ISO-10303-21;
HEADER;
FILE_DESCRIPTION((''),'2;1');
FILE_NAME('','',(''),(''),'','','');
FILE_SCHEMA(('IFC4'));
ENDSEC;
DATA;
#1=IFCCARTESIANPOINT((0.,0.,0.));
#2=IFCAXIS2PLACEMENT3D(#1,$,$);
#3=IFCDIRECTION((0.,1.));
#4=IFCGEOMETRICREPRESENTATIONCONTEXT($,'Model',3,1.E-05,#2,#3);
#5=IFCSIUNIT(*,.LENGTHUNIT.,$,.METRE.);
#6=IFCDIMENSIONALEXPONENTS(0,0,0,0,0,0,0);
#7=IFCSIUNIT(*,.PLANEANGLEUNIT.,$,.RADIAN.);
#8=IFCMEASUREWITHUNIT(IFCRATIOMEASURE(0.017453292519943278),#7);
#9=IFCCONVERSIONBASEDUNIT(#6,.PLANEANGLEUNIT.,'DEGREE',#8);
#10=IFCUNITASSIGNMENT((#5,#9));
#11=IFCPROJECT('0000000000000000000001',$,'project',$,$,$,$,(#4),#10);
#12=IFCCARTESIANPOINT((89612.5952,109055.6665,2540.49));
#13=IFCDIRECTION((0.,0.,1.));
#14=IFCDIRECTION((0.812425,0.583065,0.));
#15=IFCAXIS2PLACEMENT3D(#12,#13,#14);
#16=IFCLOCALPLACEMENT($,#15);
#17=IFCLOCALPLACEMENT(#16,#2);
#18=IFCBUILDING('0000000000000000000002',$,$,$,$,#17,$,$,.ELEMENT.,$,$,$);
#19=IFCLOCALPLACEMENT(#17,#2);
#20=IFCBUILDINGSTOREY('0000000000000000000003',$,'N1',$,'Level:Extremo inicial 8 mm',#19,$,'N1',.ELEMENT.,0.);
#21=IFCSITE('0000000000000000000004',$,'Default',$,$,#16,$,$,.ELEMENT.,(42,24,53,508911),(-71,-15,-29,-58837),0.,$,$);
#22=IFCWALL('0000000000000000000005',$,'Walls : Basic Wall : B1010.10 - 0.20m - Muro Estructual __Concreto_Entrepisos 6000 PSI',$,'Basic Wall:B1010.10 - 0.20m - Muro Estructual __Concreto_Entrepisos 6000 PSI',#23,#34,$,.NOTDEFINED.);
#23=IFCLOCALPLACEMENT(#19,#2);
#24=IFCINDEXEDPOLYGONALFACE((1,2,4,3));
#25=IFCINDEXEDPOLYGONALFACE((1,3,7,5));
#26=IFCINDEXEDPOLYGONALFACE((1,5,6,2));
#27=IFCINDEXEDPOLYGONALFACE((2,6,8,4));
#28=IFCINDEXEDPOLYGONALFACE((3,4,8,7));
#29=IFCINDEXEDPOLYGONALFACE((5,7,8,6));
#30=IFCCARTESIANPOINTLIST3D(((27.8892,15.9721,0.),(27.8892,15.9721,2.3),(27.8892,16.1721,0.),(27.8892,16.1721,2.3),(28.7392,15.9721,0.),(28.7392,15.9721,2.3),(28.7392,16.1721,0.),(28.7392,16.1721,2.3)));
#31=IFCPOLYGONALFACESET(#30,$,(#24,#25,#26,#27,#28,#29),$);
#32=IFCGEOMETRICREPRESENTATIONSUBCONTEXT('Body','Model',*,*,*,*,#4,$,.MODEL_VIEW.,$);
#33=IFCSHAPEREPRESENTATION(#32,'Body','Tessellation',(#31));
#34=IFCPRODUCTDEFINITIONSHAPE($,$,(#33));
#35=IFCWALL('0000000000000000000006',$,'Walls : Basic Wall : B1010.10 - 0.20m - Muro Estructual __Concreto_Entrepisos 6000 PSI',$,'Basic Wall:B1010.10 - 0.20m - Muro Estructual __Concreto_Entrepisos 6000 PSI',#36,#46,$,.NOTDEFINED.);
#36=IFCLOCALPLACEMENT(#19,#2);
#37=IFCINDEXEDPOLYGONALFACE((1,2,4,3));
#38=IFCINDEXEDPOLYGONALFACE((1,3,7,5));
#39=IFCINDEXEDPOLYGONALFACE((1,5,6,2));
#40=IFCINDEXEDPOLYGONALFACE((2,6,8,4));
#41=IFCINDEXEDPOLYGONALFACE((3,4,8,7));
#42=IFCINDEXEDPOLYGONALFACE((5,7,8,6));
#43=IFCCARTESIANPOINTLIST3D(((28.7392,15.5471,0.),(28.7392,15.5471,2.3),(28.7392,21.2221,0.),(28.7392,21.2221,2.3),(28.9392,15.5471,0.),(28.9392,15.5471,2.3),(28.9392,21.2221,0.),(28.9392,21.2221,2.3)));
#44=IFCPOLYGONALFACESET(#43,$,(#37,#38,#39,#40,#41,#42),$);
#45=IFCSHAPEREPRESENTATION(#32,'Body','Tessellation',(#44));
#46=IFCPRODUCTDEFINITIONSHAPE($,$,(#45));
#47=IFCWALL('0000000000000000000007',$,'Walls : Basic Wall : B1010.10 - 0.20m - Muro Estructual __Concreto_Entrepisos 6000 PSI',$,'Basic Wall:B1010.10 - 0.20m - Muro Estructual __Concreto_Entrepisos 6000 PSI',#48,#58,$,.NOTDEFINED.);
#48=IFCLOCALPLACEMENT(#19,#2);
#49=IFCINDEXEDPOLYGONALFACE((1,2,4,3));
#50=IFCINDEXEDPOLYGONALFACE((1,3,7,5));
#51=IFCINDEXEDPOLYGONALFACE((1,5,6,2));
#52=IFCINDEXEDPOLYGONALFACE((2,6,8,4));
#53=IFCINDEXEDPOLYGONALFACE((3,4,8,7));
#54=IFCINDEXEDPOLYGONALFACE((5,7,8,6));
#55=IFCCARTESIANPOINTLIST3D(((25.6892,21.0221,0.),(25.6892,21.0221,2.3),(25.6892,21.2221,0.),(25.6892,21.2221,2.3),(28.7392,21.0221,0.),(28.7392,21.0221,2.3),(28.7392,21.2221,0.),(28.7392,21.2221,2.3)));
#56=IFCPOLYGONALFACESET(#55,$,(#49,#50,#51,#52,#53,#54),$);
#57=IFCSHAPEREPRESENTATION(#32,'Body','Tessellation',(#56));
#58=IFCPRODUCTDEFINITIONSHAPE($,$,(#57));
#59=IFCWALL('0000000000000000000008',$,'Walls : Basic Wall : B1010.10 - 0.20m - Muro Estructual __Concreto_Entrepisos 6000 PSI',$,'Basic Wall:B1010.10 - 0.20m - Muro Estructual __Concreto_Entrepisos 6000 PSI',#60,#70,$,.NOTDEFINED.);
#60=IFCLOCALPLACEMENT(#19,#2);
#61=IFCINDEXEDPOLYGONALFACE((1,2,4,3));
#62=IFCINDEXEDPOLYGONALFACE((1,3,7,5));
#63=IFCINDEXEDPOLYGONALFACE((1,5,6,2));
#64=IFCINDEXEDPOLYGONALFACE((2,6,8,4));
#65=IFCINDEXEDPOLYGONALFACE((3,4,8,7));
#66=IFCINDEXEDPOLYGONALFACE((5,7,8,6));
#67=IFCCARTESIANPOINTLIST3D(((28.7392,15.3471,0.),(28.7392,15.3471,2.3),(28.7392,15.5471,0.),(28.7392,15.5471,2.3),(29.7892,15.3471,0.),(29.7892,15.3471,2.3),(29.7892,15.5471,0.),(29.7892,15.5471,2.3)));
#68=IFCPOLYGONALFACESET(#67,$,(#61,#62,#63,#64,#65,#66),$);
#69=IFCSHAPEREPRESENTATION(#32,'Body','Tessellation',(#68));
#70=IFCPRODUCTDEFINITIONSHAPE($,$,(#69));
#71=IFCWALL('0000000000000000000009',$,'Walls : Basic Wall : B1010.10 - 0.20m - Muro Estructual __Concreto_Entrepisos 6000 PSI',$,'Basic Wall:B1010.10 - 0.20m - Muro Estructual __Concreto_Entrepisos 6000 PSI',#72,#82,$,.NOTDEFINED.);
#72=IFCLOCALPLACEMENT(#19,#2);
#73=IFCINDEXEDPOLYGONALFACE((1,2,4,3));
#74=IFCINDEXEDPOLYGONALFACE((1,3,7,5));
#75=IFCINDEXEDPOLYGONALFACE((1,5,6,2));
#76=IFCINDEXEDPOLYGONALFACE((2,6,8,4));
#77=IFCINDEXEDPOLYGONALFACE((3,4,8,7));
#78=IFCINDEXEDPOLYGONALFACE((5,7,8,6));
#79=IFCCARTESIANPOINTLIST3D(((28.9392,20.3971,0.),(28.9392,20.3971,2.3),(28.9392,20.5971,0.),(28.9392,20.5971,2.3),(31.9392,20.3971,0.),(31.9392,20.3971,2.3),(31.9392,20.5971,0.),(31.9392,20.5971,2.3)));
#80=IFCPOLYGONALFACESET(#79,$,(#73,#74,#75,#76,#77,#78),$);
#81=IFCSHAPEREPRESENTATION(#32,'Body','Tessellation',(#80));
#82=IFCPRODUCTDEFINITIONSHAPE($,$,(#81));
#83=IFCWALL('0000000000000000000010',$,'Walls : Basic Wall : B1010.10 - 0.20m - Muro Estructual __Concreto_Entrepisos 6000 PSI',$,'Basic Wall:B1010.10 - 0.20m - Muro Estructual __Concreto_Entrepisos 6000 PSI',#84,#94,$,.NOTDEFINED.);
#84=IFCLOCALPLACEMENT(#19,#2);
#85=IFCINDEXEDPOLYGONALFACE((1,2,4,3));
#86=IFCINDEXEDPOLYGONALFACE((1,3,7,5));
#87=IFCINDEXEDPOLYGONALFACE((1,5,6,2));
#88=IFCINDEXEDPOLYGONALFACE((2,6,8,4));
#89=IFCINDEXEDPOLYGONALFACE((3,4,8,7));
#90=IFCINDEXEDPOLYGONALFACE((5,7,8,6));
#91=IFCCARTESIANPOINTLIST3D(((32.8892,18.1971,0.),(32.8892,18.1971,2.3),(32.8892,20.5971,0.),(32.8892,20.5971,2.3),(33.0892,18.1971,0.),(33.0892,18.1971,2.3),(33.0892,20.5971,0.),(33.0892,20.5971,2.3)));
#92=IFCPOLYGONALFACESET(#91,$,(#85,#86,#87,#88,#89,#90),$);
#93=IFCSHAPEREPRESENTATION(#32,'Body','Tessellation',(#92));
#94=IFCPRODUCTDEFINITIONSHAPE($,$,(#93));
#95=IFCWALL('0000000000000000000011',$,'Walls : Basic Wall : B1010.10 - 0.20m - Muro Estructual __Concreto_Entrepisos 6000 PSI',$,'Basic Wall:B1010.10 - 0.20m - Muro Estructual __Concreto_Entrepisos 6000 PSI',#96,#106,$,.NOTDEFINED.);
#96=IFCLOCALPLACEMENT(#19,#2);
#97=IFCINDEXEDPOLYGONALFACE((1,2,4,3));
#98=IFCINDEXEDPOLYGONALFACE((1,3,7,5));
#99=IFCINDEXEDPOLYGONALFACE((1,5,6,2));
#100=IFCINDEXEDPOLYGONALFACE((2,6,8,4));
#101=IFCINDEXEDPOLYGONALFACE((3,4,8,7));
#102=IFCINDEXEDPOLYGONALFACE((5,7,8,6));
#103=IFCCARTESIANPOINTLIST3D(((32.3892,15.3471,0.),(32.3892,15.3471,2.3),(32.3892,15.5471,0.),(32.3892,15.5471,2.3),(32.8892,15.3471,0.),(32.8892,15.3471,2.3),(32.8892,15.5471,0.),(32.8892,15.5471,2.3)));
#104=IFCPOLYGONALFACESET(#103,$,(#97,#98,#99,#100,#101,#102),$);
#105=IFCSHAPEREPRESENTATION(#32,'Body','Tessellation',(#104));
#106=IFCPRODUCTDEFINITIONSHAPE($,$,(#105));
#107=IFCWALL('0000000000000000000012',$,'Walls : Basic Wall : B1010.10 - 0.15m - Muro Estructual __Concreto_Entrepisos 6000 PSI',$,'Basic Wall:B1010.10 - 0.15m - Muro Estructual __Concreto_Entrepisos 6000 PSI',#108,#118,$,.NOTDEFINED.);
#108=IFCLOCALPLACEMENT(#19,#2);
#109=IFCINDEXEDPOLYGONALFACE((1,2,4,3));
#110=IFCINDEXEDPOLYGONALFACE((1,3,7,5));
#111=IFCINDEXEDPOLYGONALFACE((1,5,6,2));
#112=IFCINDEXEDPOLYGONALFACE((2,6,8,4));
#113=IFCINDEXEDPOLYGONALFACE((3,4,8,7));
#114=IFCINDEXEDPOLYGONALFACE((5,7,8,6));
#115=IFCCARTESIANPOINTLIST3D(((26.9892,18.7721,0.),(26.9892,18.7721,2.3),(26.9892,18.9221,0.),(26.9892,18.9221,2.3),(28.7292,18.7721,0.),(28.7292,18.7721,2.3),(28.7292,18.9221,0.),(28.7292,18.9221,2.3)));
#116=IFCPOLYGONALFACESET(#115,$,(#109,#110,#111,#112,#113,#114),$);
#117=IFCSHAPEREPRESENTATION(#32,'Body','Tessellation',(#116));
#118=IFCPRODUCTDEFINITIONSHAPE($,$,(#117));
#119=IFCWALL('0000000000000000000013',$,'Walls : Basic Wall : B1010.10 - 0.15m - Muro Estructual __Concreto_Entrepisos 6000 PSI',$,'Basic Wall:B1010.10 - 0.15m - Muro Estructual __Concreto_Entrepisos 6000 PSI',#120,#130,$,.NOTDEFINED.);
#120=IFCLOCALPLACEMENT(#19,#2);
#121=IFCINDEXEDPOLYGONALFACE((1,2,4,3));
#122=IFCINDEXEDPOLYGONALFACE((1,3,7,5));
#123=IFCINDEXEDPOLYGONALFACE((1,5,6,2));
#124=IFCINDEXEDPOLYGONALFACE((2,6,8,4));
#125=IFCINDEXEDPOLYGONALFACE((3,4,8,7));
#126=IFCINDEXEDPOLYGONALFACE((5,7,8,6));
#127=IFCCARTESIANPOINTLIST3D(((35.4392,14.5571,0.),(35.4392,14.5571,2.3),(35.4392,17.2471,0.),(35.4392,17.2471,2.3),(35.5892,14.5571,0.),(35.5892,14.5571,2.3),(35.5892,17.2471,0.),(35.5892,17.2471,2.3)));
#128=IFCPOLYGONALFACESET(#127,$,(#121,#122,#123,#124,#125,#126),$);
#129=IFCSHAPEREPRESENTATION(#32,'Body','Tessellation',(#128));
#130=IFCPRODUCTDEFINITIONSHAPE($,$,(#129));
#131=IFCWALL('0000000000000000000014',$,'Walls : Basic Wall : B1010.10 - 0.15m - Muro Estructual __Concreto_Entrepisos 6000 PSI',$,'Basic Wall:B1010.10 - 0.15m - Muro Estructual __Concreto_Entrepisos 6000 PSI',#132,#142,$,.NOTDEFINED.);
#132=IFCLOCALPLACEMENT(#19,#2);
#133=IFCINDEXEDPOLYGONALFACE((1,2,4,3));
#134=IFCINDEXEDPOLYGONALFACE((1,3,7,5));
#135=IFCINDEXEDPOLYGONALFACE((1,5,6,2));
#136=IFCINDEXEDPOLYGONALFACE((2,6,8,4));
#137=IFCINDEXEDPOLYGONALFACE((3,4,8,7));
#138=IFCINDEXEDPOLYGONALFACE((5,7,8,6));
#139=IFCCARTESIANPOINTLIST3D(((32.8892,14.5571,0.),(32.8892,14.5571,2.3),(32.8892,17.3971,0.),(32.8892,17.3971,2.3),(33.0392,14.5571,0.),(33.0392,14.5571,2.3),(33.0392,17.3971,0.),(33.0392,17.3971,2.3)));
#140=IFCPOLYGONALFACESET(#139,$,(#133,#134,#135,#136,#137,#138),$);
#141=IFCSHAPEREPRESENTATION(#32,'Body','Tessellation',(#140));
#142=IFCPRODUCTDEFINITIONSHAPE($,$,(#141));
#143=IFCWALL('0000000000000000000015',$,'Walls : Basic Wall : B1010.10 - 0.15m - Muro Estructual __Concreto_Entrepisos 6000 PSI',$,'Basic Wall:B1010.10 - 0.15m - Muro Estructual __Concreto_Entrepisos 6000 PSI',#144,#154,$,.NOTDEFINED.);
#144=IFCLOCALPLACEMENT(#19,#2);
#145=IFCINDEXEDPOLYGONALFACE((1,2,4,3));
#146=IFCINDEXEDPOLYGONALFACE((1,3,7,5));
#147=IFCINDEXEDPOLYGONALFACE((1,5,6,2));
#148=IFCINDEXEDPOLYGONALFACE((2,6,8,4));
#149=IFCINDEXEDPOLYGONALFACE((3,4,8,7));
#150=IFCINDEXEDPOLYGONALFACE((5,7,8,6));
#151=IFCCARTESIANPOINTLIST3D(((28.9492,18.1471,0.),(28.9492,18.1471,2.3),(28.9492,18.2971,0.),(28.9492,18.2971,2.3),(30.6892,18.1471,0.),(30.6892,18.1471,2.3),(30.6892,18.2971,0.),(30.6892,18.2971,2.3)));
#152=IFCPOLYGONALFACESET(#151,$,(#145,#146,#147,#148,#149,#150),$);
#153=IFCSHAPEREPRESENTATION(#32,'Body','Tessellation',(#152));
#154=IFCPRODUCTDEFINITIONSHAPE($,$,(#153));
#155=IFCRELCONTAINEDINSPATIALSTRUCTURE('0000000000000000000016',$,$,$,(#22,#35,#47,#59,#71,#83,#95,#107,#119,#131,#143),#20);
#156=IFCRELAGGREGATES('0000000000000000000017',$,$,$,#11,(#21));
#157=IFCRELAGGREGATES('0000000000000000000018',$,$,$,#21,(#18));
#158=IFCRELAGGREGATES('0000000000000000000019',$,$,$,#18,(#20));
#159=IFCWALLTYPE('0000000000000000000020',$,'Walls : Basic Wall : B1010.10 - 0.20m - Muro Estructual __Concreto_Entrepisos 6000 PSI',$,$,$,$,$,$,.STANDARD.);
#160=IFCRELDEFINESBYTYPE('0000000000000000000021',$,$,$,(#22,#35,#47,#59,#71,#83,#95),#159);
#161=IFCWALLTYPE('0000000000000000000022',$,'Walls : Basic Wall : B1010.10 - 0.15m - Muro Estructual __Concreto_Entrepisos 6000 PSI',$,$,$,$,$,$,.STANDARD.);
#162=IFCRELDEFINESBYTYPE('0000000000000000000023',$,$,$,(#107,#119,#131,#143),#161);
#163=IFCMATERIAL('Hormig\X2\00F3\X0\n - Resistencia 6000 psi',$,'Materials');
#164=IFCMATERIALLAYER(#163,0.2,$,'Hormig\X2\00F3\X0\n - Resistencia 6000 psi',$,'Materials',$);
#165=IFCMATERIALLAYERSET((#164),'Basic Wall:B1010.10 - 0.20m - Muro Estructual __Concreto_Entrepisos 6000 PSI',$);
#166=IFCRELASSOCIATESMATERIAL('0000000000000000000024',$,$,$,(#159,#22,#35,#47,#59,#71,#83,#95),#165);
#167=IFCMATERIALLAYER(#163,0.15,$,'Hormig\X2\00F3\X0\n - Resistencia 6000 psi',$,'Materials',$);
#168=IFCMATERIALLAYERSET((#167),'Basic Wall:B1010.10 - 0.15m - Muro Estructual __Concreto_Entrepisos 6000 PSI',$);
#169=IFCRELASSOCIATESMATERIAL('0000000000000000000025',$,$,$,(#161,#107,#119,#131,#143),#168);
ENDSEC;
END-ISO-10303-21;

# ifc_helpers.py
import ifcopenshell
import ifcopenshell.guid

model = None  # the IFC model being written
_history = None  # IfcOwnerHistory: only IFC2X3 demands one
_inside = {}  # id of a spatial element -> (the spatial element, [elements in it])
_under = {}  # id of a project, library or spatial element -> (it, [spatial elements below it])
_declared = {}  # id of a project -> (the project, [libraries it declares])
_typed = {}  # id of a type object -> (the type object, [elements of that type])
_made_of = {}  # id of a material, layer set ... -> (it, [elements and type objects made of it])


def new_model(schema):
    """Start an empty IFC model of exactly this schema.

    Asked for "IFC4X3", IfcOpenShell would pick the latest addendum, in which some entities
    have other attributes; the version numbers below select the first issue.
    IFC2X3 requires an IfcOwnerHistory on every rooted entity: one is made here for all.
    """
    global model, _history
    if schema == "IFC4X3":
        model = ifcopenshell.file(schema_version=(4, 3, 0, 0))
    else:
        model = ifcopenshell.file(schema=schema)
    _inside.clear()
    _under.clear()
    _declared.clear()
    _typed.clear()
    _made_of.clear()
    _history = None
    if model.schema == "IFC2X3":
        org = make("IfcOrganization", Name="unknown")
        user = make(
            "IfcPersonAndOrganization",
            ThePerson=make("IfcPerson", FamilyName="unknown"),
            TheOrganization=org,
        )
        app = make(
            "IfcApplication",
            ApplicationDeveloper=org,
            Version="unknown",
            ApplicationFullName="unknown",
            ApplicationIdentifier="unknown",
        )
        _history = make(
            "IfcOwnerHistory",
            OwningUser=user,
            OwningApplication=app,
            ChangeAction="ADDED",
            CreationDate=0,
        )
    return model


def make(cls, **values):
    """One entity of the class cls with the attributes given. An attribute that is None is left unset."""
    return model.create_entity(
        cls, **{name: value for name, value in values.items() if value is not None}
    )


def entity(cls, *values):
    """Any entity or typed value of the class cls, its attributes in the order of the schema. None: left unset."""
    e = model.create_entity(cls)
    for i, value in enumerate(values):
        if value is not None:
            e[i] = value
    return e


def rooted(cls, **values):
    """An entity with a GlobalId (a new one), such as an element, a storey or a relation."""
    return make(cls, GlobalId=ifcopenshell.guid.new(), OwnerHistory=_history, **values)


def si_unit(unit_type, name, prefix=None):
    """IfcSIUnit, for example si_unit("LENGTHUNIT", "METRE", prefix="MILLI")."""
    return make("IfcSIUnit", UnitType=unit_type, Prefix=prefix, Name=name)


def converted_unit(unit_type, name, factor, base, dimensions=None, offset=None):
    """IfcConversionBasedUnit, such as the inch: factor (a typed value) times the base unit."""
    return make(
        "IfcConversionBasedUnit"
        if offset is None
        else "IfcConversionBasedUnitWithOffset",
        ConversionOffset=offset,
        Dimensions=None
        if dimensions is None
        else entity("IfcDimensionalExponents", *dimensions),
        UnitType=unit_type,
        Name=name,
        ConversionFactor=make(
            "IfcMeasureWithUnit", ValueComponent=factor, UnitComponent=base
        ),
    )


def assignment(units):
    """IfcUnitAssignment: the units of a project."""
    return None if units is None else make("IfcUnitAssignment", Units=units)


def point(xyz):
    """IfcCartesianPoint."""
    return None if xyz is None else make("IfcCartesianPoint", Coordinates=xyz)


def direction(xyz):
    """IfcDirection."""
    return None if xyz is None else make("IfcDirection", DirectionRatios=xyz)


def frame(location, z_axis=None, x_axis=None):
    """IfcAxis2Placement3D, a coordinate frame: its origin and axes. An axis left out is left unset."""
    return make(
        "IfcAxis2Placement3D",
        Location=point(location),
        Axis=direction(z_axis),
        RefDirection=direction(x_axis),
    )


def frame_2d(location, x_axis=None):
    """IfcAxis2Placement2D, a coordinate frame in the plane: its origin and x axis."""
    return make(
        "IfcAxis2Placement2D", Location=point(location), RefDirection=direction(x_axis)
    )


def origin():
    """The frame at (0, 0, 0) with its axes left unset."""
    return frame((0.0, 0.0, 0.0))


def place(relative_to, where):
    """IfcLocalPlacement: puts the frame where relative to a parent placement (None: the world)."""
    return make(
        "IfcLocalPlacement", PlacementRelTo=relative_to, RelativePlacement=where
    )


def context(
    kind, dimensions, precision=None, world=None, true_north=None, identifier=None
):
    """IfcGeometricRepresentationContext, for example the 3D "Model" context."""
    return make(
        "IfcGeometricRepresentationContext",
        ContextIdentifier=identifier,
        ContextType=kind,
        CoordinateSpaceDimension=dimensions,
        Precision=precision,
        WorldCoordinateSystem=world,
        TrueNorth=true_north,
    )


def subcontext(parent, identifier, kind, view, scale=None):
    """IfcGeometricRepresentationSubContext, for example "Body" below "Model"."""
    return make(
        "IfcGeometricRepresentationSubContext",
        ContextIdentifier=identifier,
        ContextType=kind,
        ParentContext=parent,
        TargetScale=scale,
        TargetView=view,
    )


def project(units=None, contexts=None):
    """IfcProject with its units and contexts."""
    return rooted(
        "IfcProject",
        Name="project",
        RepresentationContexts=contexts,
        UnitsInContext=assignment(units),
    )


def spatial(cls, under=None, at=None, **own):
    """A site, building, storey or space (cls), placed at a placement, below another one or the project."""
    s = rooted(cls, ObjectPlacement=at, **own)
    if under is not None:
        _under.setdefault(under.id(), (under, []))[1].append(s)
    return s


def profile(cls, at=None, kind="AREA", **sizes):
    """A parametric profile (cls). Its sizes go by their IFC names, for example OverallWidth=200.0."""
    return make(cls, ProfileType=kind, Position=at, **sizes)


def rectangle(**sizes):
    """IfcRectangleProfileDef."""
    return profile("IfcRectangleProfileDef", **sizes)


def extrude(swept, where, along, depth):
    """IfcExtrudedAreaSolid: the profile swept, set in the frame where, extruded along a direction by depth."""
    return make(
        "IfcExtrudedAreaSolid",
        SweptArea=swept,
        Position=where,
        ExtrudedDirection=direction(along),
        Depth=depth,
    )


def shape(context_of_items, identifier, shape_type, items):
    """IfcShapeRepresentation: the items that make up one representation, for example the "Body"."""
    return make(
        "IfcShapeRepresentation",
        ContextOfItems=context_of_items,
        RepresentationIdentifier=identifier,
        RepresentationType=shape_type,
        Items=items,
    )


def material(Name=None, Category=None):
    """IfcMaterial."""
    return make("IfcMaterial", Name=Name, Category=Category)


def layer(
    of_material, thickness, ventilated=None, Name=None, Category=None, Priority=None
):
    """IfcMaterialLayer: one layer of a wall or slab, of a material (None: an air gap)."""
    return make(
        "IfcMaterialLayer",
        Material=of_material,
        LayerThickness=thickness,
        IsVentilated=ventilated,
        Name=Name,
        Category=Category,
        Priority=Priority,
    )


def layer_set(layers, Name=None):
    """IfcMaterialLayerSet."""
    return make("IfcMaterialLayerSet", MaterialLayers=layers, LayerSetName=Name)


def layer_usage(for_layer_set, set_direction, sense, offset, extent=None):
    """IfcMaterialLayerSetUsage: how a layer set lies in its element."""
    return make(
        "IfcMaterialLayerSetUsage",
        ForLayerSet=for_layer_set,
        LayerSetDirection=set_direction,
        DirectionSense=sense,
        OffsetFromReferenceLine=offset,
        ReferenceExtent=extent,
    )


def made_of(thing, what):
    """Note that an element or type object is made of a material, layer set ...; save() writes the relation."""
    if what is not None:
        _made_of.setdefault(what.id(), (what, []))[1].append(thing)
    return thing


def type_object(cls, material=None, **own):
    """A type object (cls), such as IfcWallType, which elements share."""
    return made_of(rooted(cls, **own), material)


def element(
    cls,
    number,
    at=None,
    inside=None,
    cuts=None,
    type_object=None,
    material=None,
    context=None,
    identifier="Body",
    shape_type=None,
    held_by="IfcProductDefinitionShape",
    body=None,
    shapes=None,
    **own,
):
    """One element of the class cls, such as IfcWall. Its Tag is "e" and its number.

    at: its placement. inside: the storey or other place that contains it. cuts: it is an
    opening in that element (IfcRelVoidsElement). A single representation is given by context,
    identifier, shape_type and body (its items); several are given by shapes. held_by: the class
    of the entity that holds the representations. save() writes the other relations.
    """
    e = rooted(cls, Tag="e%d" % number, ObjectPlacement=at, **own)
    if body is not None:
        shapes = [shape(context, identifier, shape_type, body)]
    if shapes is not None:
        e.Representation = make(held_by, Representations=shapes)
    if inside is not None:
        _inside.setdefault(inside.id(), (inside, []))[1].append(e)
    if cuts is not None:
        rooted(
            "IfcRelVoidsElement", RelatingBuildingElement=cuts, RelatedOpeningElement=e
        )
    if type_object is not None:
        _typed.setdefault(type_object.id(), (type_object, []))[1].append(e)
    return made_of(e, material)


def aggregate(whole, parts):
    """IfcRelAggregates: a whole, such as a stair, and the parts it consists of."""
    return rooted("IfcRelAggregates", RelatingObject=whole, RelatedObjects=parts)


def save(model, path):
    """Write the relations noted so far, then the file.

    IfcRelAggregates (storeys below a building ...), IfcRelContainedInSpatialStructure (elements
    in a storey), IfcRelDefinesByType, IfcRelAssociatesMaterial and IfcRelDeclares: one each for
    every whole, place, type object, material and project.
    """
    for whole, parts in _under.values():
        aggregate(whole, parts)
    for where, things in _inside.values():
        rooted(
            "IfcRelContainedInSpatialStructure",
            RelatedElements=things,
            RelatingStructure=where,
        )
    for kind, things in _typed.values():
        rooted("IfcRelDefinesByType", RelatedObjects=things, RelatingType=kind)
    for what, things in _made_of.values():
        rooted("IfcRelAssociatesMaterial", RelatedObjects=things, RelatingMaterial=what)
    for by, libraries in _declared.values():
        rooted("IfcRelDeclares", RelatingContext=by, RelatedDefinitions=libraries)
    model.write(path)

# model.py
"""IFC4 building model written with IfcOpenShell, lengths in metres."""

from ifc_helpers import new_model, entity, si_unit, converted_unit, direction, frame, frame_2d, origin, place, context, subcontext, project, spatial, rectangle, extrude, material, layer, layer_set, layer_usage, type_object, element, save


model = new_model("IFC4")

# Units and contexts
model_context = context("Model", 3, precision=1e-05, world=origin(), true_north=direction((0.0, 1.0)))
body_context = subcontext(model_context, "Body", "Model", "MODEL_VIEW")
ifc_project = project(units=[si_unit("LENGTHUNIT", "METRE"), converted_unit("PLANEANGLEUNIT", "DEGREE", entity("IfcRatioMeasure", 0.017453292519943278), si_unit("PLANEANGLEUNIT", "RADIAN"), dimensions=[0, 0, 0, 0, 0, 0, 0])], contexts=[model_context])

# Site, building, storey
site_placement = place(None, frame((89612.5952, 109055.6665, 2540.49), z_axis=(0.0, 0.0, 1.0), x_axis=(0.812425, 0.583065, 0.0)))
site = spatial("IfcSite", under=ifc_project, at=site_placement, Name="Default", CompositionType="ELEMENT", RefLatitude=(42, 24, 53, 508911), RefLongitude=(-71, -15, -29, -58837), RefElevation=0.0)
building_placement = place(site_placement, origin())
building = spatial("IfcBuilding", under=site, at=building_placement, CompositionType="ELEMENT")
storey_placement = place(building_placement, origin())
storey = spatial("IfcBuildingStorey", under=building, at=storey_placement, Name="N1", ObjectType="Level:Extremo inicial 8 mm", LongName="N1", CompositionType="ELEMENT", Elevation=0.0)

# Walls
ifc_material_1 = material(Name="Hormigón - Resistencia 6000 psi", Category="Materials")
ifc_layer_1 = layer(ifc_material_1, 0.2, Name="Hormigón - Resistencia 6000 psi", Category="Materials")
ifc_layer_set_1 = layer_set([ifc_layer_1], Name="Basic Wall:B1010.10 - 0.20m - Muro Estructual __Concreto_Entrepisos 6000 PSI")
ifc_layer_usage_1 = layer_usage(ifc_layer_set_1, "AXIS2", "POSITIVE", -0.1)
wall_type_1 = type_object("IfcWallType", Name="Walls : Basic Wall : B1010.10 - 0.20m - Muro Estructual __Concreto_Entrepisos 6000 PSI", PredefinedType="STANDARD", material=ifc_layer_set_1)
wall_1_placement = place(storey_placement, frame((27.8892, 16.0721, 0.0)))
element("IfcWall", 1, at=wall_1_placement, inside=storey, type_object=wall_type_1, material=ifc_layer_usage_1, Name="Walls : Basic Wall : B1010.10 - 0.20m - Muro Estructual __Concreto_Entrepisos 6000 PSI", ObjectType="Basic Wall:B1010.10 - 0.20m - Muro Estructual __Concreto_Entrepisos 6000 PSI", PredefinedType="NOTDEFINED", context=body_context, shape_type="SweptSolid", body=[
    extrude(rectangle(XDim=0.85, YDim=0.2, at=frame_2d((0.425, 0.0), x_axis=(-1.0, 0.0))), origin(), (0.0, 0.0, 1.0), 2.3),
])
ifc_layer_usage_2 = layer_usage(ifc_layer_set_1, "AXIS2", "POSITIVE", -0.1)
wall_2_placement = place(storey_placement, frame((28.8392, 15.5471, 0.0), z_axis=(0.0, 0.0, 1.0), x_axis=(0.0, 1.0, 0.0)))
element("IfcWall", 2, at=wall_2_placement, inside=storey, type_object=wall_type_1, material=ifc_layer_usage_2, Name="Walls : Basic Wall : B1010.10 - 0.20m - Muro Estructual __Concreto_Entrepisos 6000 PSI", ObjectType="Basic Wall:B1010.10 - 0.20m - Muro Estructual __Concreto_Entrepisos 6000 PSI", PredefinedType="NOTDEFINED", context=body_context, shape_type="SweptSolid", body=[
    extrude(rectangle(XDim=5.675, YDim=0.2, at=frame_2d((2.8375, 0.0), x_axis=(-1.0, 0.0))), origin(), (0.0, 0.0, 1.0), 2.3),
])
ifc_layer_usage_3 = layer_usage(ifc_layer_set_1, "AXIS2", "POSITIVE", -0.1)
wall_3_placement = place(storey_placement, frame((28.7392, 21.1221, 0.0), z_axis=(0.0, 0.0, 1.0), x_axis=(-1.0, 0.0, 0.0)))
element("IfcWall", 3, at=wall_3_placement, inside=storey, type_object=wall_type_1, material=ifc_layer_usage_3, Name="Walls : Basic Wall : B1010.10 - 0.20m - Muro Estructual __Concreto_Entrepisos 6000 PSI", ObjectType="Basic Wall:B1010.10 - 0.20m - Muro Estructual __Concreto_Entrepisos 6000 PSI", PredefinedType="NOTDEFINED", context=body_context, shape_type="SweptSolid", body=[
    extrude(rectangle(XDim=3.05, YDim=0.2, at=frame_2d((1.525, 0.0), x_axis=(-1.0, 0.0))), origin(), (0.0, 0.0, 1.0), 2.3),
])
ifc_layer_usage_4 = layer_usage(ifc_layer_set_1, "AXIS2", "NEGATIVE", 0.1)
wall_4_placement = place(storey_placement, frame((29.7892, 15.4471, 0.0), z_axis=(0.0, 0.0, 1.0), x_axis=(-1.0, 0.0, 0.0)))
element("IfcWall", 4, at=wall_4_placement, inside=storey, type_object=wall_type_1, material=ifc_layer_usage_4, Name="Walls : Basic Wall : B1010.10 - 0.20m - Muro Estructual __Concreto_Entrepisos 6000 PSI", ObjectType="Basic Wall:B1010.10 - 0.20m - Muro Estructual __Concreto_Entrepisos 6000 PSI", PredefinedType="NOTDEFINED", context=body_context, shape_type="SweptSolid", body=[
    extrude(rectangle(XDim=1.05, YDim=0.2, at=frame_2d((0.525, 0.0), x_axis=(-1.0, 0.0))), origin(), (0.0, 0.0, 1.0), 2.3),
])
ifc_layer_usage_5 = layer_usage(ifc_layer_set_1, "AXIS2", "NEGATIVE", 0.1)
wall_5_placement = place(storey_placement, frame((28.9392, 20.4971, 0.0)))
element("IfcWall", 5, at=wall_5_placement, inside=storey, type_object=wall_type_1, material=ifc_layer_usage_5, Name="Walls : Basic Wall : B1010.10 - 0.20m - Muro Estructual __Concreto_Entrepisos 6000 PSI", ObjectType="Basic Wall:B1010.10 - 0.20m - Muro Estructual __Concreto_Entrepisos 6000 PSI", PredefinedType="NOTDEFINED", context=body_context, shape_type="SweptSolid", body=[
    extrude(rectangle(XDim=3.0, YDim=0.2, at=frame_2d((1.5, 0.0), x_axis=(-1.0, 0.0))), origin(), (0.0, 0.0, 1.0), 2.3),
])
ifc_layer_usage_6 = layer_usage(ifc_layer_set_1, "AXIS2", "NEGATIVE", 0.1)
wall_6_placement = place(storey_placement, frame((32.9892, 18.1971, 0.0), z_axis=(0.0, 0.0, 1.0), x_axis=(0.0, 1.0, 0.0)))
element("IfcWall", 6, at=wall_6_placement, inside=storey, type_object=wall_type_1, material=ifc_layer_usage_6, Name="Walls : Basic Wall : B1010.10 - 0.20m - Muro Estructual __Concreto_Entrepisos 6000 PSI", ObjectType="Basic Wall:B1010.10 - 0.20m - Muro Estructual __Concreto_Entrepisos 6000 PSI", PredefinedType="NOTDEFINED", context=body_context, shape_type="SweptSolid", body=[
    extrude(rectangle(XDim=2.4, YDim=0.2, at=frame_2d((1.2, 0.0), x_axis=(-1.0, 0.0))), origin(), (0.0, 0.0, 1.0), 2.3),
])
ifc_layer_usage_7 = layer_usage(ifc_layer_set_1, "AXIS2", "NEGATIVE", 0.1)
wall_7_placement = place(storey_placement, frame((32.3892, 15.4471, 0.0)))
element("IfcWall", 7, at=wall_7_placement, inside=storey, type_object=wall_type_1, material=ifc_layer_usage_7, Name="Walls : Basic Wall : B1010.10 - 0.20m - Muro Estructual __Concreto_Entrepisos 6000 PSI", ObjectType="Basic Wall:B1010.10 - 0.20m - Muro Estructual __Concreto_Entrepisos 6000 PSI", PredefinedType="NOTDEFINED", context=body_context, shape_type="SweptSolid", body=[
    extrude(rectangle(XDim=0.5, YDim=0.2, at=frame_2d((0.25, 0.0), x_axis=(-1.0, 0.0))), origin(), (0.0, 0.0, 1.0), 2.3),
])
ifc_layer_2 = layer(ifc_material_1, 0.15, Name="Hormigón - Resistencia 6000 psi", Category="Materials")
ifc_layer_set_2 = layer_set([ifc_layer_2], Name="Basic Wall:B1010.10 - 0.15m - Muro Estructual __Concreto_Entrepisos 6000 PSI")
ifc_layer_usage_8 = layer_usage(ifc_layer_set_2, "AXIS2", "POSITIVE", -0.075)
wall_type_2 = type_object("IfcWallType", Name="Walls : Basic Wall : B1010.10 - 0.15m - Muro Estructual __Concreto_Entrepisos 6000 PSI", PredefinedType="STANDARD", material=ifc_layer_set_2)
wall_8_placement = place(storey_placement, frame((26.9892, 18.8471, 0.0)))
element("IfcWall", 8, at=wall_8_placement, inside=storey, type_object=wall_type_2, material=ifc_layer_usage_8, Name="Walls : Basic Wall : B1010.10 - 0.15m - Muro Estructual __Concreto_Entrepisos 6000 PSI", ObjectType="Basic Wall:B1010.10 - 0.15m - Muro Estructual __Concreto_Entrepisos 6000 PSI", PredefinedType="NOTDEFINED", context=body_context, shape_type="SweptSolid", body=[
    extrude(rectangle(XDim=1.74, YDim=0.15, at=frame_2d((0.87, 0.0), x_axis=(-1.0, 0.0))), origin(), (0.0, 0.0, 1.0), 2.3),
])
ifc_layer_usage_9 = layer_usage(ifc_layer_set_2, "AXIS2", "NEGATIVE", 0.075)
wall_9_placement = place(storey_placement, frame((35.5142, 14.5571, 0.0), z_axis=(0.0, 0.0, 1.0), x_axis=(0.0, 1.0, 0.0)))
element("IfcWall", 9, at=wall_9_placement, inside=storey, type_object=wall_type_2, material=ifc_layer_usage_9, Name="Walls : Basic Wall : B1010.10 - 0.15m - Muro Estructual __Concreto_Entrepisos 6000 PSI", ObjectType="Basic Wall:B1010.10 - 0.15m - Muro Estructual __Concreto_Entrepisos 6000 PSI", PredefinedType="NOTDEFINED", context=body_context, shape_type="SweptSolid", body=[
    extrude(rectangle(XDim=2.69, YDim=0.15, at=frame_2d((1.345, 0.0), x_axis=(-1.0, 0.0))), origin(), (0.0, 0.0, 1.0), 2.3),
])
ifc_layer_usage_10 = layer_usage(ifc_layer_set_2, "AXIS2", "NEGATIVE", 0.075)
wall_10_placement = place(storey_placement, frame((32.9642, 14.5571, 0.0), z_axis=(0.0, 0.0, 1.0), x_axis=(0.0, 1.0, 0.0)))
element("IfcWall", 10, at=wall_10_placement, inside=storey, type_object=wall_type_2, material=ifc_layer_usage_10, Name="Walls : Basic Wall : B1010.10 - 0.15m - Muro Estructual __Concreto_Entrepisos 6000 PSI", ObjectType="Basic Wall:B1010.10 - 0.15m - Muro Estructual __Concreto_Entrepisos 6000 PSI", PredefinedType="NOTDEFINED", context=body_context, shape_type="SweptSolid", body=[
    extrude(rectangle(XDim=2.84, YDim=0.15, at=frame_2d((1.42, 0.0), x_axis=(-1.0, 0.0))), origin(), (0.0, 0.0, 1.0), 2.3),
])
ifc_layer_usage_11 = layer_usage(ifc_layer_set_2, "AXIS2", "NEGATIVE", 0.075)
wall_11_placement = place(storey_placement, frame((30.6892, 18.2221, 0.0), z_axis=(0.0, 0.0, 1.0), x_axis=(-1.0, 0.0, 0.0)))
element("IfcWall", 11, at=wall_11_placement, inside=storey, type_object=wall_type_2, material=ifc_layer_usage_11, Name="Walls : Basic Wall : B1010.10 - 0.15m - Muro Estructual __Concreto_Entrepisos 6000 PSI", ObjectType="Basic Wall:B1010.10 - 0.15m - Muro Estructual __Concreto_Entrepisos 6000 PSI", PredefinedType="NOTDEFINED", context=body_context, shape_type="SweptSolid", body=[
    extrude(rectangle(XDim=1.74, YDim=0.15, at=frame_2d((0.87, 0.0), x_axis=(-1.0, 0.0))), origin(), (0.0, 0.0, 1.0), 2.3),
])

save(model, "model.ifc")
